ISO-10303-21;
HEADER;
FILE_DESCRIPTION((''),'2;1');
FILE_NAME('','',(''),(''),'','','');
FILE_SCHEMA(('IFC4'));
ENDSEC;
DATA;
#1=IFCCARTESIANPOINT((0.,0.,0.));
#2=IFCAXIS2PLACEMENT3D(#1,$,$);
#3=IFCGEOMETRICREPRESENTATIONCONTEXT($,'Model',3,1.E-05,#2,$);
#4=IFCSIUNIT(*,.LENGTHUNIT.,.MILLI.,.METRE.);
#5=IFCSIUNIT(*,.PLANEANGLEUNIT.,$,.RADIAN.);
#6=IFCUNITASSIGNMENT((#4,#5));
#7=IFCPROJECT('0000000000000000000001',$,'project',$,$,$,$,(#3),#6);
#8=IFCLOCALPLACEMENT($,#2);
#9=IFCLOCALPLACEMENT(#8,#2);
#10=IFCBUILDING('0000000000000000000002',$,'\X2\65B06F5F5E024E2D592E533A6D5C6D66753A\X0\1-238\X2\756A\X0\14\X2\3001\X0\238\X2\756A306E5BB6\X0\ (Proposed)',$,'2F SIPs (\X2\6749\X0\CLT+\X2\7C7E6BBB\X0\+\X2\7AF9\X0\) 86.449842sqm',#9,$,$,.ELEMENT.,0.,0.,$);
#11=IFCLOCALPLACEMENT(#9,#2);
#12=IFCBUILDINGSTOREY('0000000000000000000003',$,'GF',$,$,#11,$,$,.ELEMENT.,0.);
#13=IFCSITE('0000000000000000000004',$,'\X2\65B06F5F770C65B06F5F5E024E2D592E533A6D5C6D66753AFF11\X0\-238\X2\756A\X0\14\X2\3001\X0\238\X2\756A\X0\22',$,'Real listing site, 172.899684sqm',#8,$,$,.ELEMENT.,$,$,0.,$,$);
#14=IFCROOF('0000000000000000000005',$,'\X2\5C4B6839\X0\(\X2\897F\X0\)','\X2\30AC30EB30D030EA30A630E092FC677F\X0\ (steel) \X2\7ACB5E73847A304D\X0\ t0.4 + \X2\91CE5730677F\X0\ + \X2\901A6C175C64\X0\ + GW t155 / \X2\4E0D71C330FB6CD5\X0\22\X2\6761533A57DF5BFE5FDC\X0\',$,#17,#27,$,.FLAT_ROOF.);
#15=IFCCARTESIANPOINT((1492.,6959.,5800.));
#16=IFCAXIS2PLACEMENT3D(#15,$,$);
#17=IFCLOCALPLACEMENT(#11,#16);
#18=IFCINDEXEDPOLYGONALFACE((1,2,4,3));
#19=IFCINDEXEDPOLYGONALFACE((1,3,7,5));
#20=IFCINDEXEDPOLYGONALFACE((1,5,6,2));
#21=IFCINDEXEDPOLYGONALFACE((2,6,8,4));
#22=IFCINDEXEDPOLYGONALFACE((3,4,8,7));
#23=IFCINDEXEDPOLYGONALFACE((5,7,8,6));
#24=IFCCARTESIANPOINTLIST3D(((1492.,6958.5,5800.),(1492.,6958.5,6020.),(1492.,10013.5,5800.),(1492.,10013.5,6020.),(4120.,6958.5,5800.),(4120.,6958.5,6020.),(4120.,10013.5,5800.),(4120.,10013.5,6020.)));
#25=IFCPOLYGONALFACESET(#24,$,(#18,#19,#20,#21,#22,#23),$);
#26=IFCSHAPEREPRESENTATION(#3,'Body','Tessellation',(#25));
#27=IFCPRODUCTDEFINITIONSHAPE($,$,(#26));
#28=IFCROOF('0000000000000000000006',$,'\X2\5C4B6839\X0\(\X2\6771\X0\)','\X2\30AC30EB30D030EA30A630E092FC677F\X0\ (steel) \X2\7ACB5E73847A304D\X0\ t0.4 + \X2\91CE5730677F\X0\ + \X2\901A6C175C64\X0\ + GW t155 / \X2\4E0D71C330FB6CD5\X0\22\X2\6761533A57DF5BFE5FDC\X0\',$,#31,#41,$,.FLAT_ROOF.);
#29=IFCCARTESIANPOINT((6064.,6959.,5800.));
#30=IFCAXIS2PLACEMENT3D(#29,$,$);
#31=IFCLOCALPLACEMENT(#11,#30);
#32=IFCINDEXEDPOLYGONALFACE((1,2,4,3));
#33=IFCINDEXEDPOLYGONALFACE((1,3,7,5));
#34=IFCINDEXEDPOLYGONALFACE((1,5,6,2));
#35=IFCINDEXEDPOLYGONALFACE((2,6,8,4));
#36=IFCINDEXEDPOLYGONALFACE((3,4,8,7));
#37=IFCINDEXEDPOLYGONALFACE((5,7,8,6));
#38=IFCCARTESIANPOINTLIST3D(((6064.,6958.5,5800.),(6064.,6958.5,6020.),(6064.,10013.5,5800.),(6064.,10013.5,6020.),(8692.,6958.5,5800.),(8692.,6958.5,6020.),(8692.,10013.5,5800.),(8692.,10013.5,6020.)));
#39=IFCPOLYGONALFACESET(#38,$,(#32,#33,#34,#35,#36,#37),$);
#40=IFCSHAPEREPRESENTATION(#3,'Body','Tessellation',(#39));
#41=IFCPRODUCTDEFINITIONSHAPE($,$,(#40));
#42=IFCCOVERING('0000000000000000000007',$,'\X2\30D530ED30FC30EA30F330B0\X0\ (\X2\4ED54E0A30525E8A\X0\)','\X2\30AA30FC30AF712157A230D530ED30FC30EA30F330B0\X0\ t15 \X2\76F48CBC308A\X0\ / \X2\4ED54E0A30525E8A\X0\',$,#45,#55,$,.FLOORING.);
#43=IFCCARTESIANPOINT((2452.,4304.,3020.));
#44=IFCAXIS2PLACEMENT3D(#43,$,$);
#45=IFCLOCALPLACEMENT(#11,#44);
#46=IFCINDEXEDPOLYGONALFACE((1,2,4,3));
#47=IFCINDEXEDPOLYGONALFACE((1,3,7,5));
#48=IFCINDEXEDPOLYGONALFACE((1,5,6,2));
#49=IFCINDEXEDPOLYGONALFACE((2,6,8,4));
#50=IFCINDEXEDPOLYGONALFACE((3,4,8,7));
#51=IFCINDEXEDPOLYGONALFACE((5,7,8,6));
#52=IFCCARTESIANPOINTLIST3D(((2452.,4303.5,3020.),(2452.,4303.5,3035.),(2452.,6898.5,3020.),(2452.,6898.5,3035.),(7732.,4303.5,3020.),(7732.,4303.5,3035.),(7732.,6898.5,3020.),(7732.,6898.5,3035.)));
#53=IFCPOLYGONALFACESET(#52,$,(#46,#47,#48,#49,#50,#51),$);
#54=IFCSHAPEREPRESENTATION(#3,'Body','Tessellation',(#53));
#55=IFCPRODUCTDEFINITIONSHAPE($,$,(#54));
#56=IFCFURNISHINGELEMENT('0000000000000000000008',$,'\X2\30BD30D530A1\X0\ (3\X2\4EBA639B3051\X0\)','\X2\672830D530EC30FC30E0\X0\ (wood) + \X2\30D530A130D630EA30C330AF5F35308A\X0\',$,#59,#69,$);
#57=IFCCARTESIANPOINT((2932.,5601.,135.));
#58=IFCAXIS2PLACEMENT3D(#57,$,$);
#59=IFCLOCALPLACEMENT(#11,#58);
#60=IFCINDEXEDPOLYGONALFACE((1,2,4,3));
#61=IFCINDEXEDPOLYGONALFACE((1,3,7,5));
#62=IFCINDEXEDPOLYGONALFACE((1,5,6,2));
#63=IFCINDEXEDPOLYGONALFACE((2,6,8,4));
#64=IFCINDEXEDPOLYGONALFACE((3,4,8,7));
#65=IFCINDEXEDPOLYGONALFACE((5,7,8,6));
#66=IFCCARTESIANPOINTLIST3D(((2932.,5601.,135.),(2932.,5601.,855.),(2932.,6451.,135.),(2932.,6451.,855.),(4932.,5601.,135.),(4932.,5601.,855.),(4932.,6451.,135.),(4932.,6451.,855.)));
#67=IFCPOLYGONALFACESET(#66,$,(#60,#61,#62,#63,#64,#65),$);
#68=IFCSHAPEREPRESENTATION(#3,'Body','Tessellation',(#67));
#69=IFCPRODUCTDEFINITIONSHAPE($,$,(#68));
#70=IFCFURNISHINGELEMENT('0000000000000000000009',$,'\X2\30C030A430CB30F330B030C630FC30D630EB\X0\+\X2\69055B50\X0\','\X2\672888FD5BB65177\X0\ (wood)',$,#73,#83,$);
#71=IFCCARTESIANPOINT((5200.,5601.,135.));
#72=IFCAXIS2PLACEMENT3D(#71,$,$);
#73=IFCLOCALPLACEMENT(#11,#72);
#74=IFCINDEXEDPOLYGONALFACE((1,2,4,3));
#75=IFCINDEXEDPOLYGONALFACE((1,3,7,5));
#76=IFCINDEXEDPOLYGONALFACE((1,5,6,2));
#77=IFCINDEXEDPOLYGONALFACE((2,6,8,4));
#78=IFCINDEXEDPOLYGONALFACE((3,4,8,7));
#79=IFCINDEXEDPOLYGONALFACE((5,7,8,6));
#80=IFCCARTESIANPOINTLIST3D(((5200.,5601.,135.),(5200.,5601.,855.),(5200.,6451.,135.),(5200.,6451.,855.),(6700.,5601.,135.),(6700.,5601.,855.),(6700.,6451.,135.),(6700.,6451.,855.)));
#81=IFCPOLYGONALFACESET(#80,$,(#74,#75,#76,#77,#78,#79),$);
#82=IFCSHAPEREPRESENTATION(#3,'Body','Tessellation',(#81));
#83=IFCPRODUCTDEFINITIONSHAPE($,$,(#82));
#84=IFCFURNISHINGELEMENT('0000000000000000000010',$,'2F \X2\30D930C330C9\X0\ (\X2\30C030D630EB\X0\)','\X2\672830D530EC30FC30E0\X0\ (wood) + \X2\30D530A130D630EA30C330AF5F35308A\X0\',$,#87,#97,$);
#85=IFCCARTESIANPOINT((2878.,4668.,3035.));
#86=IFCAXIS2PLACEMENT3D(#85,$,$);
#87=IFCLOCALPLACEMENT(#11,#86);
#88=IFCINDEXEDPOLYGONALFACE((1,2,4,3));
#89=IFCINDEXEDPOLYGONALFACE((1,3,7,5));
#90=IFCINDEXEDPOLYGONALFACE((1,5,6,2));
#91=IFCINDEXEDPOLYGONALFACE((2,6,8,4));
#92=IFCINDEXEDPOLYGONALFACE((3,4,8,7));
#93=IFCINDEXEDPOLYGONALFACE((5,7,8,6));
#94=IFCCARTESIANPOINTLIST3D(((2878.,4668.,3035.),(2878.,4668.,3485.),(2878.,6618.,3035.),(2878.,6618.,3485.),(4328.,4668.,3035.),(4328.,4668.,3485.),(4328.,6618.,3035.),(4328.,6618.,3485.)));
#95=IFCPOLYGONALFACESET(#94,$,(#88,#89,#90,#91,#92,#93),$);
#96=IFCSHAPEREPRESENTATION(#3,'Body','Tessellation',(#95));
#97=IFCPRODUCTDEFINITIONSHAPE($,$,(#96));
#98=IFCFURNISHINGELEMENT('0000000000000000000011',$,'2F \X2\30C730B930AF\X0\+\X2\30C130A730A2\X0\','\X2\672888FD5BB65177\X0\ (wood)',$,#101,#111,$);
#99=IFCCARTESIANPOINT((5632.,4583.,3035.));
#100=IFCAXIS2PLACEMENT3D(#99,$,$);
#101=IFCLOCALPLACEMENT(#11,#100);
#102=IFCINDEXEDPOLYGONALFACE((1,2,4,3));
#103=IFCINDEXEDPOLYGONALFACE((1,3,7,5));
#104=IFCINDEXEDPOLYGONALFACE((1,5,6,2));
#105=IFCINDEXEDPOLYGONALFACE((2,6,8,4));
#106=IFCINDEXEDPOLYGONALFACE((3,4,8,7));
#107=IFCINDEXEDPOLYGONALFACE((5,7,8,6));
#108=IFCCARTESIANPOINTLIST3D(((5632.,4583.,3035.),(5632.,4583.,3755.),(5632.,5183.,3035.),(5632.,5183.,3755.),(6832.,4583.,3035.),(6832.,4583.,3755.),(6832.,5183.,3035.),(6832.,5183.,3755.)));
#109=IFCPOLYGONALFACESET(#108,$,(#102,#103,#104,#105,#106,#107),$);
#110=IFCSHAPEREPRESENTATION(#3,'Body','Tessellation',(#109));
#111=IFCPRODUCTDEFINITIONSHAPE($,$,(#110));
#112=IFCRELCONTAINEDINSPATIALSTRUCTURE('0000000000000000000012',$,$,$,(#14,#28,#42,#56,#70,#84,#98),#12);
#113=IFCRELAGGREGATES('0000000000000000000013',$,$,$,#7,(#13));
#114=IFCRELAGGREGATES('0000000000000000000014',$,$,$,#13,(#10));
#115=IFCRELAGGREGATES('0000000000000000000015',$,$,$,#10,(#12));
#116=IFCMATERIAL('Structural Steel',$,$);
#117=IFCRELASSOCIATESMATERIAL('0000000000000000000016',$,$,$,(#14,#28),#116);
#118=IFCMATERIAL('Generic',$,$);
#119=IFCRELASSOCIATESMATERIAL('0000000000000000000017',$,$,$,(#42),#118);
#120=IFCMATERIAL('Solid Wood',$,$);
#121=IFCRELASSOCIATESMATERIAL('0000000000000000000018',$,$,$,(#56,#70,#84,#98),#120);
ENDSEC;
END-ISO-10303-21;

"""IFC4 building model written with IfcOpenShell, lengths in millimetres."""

from ifc_helpers import new_model, si_unit, frame, frame_2d, origin, place, context, project, spatial, rectangle, extrude, material, element, save


model = new_model("IFC4")

# Units and contexts
model_context = context("Model", 3, precision=1e-05, world=origin())
ifc_project = project(units=[si_unit("LENGTHUNIT", "METRE", prefix="MILLI"), si_unit("PLANEANGLEUNIT", "RADIAN")], contexts=[model_context])

# Site, building, storey
site_placement = place(None, origin())
site = spatial("IfcSite", under=ifc_project, at=site_placement, Name="新潟県新潟市中央区浜浦町１-238番14、238番22", ObjectType="Real listing site, 172.899684sqm", CompositionType="ELEMENT", RefElevation=0.0)
building_placement = place(site_placement, origin())
building = spatial("IfcBuilding", under=site, at=building_placement, Name="新潟市中央区浜浦町1-238番14、238番の家 (Proposed)", ObjectType="2F SIPs (杉CLT+籾殻+竹) 86.449842sqm", CompositionType="ELEMENT", ElevationOfRefHeight=0.0, ElevationOfTerrain=0.0)
storey_placement = place(building_placement, origin())
storey = spatial("IfcBuildingStorey", under=building, at=storey_placement, Name="GF", CompositionType="ELEMENT", Elevation=0.0)

# Shared definitions
ifc_material_1 = material(Name="Solid Wood")

# Roofs
ifc_material_2 = material(Name="Structural Steel")
roof_1_placement = place(storey_placement, frame((1492.0, 6959.0, 5800.0)))
element("IfcRoof", 1, at=roof_1_placement, inside=storey, material=ifc_material_2, Name="屋根(西)", Description="ガルバリウム鋼板 (steel) 立平葺き t0.4 + 野地板 + 通気層 + GW t155 / 不燃・法22条区域対応", PredefinedType="FLAT_ROOF", context=model_context, shape_type="SweptSolid", body=[
    extrude(rectangle(XDim=2628.0, YDim=3055.0, at=frame_2d((1314.0, 1527.0))), frame((1492.0, 6959.0, 5800.0)), (0.0, 0.0, 1.0), 220.0),
])
roof_2_placement = place(storey_placement, frame((6064.0, 6959.0, 5800.0)))
element("IfcRoof", 2, at=roof_2_placement, inside=storey, material=ifc_material_2, Name="屋根(東)", Description="ガルバリウム鋼板 (steel) 立平葺き t0.4 + 野地板 + 通気層 + GW t155 / 不燃・法22条区域対応", PredefinedType="FLAT_ROOF", context=model_context, shape_type="SweptSolid", body=[
    extrude(rectangle(XDim=2628.0, YDim=3055.0, at=frame_2d((1314.0, 1527.0))), frame((6064.0, 6959.0, 5800.0)), (0.0, 0.0, 1.0), 220.0),
])

# Covering
ifc_material_3 = material(Name="Generic")
covering_placement = place(storey_placement, frame((2452.0, 4304.0, 3020.0)))
element("IfcCovering", 3, at=covering_placement, inside=storey, material=ifc_material_3, Name="フローリング (仕上げ床)", Description="オーク無垢フローリング t15 直貼り / 仕上げ床", PredefinedType="FLOORING", context=model_context, shape_type="SweptSolid", body=[
    extrude(rectangle(XDim=5280.0, YDim=2595.0, at=frame_2d((2640.0, 1297.0))), frame((2452.0, 4304.0, 3020.0)), (0.0, 0.0, 1.0), 15.0),
])

# Furnishing elements
furnishing_1_placement = place(storey_placement, frame((2932.0, 5601.0, 135.0)))
element("IfcFurnishingElement", 4, at=furnishing_1_placement, inside=storey, material=ifc_material_1, Name="ソファ (3人掛け)", Description="木フレーム (wood) + ファブリック張り", context=model_context, shape_type="SweptSolid", body=[
    extrude(rectangle(XDim=2000.0, YDim=850.0, at=frame_2d((1000.0, 425.0))), frame((2932.0, 5601.0, 135.0)), (0.0, 0.0, 1.0), 720.0),
])
furnishing_2_placement = place(storey_placement, frame((5200.0, 5601.0, 135.0)))
element("IfcFurnishingElement", 5, at=furnishing_2_placement, inside=storey, material=ifc_material_1, Name="ダイニングテーブル+椅子", Description="木製家具 (wood)", context=model_context, shape_type="SweptSolid", body=[
    extrude(rectangle(XDim=1500.0, YDim=850.0, at=frame_2d((750.0, 425.0))), frame((5200.0, 5601.0, 135.0)), (0.0, 0.0, 1.0), 720.0),
])
furnishing_3_placement = place(storey_placement, frame((2878.0, 4668.0, 3035.0)))
element("IfcFurnishingElement", 6, at=furnishing_3_placement, inside=storey, material=ifc_material_1, Name="2F ベッド (ダブル)", Description="木フレーム (wood) + ファブリック張り", context=model_context, shape_type="SweptSolid", body=[
    extrude(rectangle(XDim=1450.0, YDim=1950.0, at=frame_2d((725.0, 975.0))), frame((2878.0, 4668.0, 3035.0)), (0.0, 0.0, 1.0), 450.0),
])
furnishing_4_placement = place(storey_placement, frame((5632.0, 4583.0, 3035.0)))
element("IfcFurnishingElement", 7, at=furnishing_4_placement, inside=storey, material=ifc_material_1, Name="2F デスク+チェア", Description="木製家具 (wood)", context=model_context, shape_type="SweptSolid", body=[
    extrude(rectangle(XDim=1200.0, YDim=600.0, at=frame_2d((600.0, 300.0))), frame((5632.0, 4583.0, 3035.0)), (0.0, 0.0, 1.0), 720.0),
])

save(model, "model.ifc")
